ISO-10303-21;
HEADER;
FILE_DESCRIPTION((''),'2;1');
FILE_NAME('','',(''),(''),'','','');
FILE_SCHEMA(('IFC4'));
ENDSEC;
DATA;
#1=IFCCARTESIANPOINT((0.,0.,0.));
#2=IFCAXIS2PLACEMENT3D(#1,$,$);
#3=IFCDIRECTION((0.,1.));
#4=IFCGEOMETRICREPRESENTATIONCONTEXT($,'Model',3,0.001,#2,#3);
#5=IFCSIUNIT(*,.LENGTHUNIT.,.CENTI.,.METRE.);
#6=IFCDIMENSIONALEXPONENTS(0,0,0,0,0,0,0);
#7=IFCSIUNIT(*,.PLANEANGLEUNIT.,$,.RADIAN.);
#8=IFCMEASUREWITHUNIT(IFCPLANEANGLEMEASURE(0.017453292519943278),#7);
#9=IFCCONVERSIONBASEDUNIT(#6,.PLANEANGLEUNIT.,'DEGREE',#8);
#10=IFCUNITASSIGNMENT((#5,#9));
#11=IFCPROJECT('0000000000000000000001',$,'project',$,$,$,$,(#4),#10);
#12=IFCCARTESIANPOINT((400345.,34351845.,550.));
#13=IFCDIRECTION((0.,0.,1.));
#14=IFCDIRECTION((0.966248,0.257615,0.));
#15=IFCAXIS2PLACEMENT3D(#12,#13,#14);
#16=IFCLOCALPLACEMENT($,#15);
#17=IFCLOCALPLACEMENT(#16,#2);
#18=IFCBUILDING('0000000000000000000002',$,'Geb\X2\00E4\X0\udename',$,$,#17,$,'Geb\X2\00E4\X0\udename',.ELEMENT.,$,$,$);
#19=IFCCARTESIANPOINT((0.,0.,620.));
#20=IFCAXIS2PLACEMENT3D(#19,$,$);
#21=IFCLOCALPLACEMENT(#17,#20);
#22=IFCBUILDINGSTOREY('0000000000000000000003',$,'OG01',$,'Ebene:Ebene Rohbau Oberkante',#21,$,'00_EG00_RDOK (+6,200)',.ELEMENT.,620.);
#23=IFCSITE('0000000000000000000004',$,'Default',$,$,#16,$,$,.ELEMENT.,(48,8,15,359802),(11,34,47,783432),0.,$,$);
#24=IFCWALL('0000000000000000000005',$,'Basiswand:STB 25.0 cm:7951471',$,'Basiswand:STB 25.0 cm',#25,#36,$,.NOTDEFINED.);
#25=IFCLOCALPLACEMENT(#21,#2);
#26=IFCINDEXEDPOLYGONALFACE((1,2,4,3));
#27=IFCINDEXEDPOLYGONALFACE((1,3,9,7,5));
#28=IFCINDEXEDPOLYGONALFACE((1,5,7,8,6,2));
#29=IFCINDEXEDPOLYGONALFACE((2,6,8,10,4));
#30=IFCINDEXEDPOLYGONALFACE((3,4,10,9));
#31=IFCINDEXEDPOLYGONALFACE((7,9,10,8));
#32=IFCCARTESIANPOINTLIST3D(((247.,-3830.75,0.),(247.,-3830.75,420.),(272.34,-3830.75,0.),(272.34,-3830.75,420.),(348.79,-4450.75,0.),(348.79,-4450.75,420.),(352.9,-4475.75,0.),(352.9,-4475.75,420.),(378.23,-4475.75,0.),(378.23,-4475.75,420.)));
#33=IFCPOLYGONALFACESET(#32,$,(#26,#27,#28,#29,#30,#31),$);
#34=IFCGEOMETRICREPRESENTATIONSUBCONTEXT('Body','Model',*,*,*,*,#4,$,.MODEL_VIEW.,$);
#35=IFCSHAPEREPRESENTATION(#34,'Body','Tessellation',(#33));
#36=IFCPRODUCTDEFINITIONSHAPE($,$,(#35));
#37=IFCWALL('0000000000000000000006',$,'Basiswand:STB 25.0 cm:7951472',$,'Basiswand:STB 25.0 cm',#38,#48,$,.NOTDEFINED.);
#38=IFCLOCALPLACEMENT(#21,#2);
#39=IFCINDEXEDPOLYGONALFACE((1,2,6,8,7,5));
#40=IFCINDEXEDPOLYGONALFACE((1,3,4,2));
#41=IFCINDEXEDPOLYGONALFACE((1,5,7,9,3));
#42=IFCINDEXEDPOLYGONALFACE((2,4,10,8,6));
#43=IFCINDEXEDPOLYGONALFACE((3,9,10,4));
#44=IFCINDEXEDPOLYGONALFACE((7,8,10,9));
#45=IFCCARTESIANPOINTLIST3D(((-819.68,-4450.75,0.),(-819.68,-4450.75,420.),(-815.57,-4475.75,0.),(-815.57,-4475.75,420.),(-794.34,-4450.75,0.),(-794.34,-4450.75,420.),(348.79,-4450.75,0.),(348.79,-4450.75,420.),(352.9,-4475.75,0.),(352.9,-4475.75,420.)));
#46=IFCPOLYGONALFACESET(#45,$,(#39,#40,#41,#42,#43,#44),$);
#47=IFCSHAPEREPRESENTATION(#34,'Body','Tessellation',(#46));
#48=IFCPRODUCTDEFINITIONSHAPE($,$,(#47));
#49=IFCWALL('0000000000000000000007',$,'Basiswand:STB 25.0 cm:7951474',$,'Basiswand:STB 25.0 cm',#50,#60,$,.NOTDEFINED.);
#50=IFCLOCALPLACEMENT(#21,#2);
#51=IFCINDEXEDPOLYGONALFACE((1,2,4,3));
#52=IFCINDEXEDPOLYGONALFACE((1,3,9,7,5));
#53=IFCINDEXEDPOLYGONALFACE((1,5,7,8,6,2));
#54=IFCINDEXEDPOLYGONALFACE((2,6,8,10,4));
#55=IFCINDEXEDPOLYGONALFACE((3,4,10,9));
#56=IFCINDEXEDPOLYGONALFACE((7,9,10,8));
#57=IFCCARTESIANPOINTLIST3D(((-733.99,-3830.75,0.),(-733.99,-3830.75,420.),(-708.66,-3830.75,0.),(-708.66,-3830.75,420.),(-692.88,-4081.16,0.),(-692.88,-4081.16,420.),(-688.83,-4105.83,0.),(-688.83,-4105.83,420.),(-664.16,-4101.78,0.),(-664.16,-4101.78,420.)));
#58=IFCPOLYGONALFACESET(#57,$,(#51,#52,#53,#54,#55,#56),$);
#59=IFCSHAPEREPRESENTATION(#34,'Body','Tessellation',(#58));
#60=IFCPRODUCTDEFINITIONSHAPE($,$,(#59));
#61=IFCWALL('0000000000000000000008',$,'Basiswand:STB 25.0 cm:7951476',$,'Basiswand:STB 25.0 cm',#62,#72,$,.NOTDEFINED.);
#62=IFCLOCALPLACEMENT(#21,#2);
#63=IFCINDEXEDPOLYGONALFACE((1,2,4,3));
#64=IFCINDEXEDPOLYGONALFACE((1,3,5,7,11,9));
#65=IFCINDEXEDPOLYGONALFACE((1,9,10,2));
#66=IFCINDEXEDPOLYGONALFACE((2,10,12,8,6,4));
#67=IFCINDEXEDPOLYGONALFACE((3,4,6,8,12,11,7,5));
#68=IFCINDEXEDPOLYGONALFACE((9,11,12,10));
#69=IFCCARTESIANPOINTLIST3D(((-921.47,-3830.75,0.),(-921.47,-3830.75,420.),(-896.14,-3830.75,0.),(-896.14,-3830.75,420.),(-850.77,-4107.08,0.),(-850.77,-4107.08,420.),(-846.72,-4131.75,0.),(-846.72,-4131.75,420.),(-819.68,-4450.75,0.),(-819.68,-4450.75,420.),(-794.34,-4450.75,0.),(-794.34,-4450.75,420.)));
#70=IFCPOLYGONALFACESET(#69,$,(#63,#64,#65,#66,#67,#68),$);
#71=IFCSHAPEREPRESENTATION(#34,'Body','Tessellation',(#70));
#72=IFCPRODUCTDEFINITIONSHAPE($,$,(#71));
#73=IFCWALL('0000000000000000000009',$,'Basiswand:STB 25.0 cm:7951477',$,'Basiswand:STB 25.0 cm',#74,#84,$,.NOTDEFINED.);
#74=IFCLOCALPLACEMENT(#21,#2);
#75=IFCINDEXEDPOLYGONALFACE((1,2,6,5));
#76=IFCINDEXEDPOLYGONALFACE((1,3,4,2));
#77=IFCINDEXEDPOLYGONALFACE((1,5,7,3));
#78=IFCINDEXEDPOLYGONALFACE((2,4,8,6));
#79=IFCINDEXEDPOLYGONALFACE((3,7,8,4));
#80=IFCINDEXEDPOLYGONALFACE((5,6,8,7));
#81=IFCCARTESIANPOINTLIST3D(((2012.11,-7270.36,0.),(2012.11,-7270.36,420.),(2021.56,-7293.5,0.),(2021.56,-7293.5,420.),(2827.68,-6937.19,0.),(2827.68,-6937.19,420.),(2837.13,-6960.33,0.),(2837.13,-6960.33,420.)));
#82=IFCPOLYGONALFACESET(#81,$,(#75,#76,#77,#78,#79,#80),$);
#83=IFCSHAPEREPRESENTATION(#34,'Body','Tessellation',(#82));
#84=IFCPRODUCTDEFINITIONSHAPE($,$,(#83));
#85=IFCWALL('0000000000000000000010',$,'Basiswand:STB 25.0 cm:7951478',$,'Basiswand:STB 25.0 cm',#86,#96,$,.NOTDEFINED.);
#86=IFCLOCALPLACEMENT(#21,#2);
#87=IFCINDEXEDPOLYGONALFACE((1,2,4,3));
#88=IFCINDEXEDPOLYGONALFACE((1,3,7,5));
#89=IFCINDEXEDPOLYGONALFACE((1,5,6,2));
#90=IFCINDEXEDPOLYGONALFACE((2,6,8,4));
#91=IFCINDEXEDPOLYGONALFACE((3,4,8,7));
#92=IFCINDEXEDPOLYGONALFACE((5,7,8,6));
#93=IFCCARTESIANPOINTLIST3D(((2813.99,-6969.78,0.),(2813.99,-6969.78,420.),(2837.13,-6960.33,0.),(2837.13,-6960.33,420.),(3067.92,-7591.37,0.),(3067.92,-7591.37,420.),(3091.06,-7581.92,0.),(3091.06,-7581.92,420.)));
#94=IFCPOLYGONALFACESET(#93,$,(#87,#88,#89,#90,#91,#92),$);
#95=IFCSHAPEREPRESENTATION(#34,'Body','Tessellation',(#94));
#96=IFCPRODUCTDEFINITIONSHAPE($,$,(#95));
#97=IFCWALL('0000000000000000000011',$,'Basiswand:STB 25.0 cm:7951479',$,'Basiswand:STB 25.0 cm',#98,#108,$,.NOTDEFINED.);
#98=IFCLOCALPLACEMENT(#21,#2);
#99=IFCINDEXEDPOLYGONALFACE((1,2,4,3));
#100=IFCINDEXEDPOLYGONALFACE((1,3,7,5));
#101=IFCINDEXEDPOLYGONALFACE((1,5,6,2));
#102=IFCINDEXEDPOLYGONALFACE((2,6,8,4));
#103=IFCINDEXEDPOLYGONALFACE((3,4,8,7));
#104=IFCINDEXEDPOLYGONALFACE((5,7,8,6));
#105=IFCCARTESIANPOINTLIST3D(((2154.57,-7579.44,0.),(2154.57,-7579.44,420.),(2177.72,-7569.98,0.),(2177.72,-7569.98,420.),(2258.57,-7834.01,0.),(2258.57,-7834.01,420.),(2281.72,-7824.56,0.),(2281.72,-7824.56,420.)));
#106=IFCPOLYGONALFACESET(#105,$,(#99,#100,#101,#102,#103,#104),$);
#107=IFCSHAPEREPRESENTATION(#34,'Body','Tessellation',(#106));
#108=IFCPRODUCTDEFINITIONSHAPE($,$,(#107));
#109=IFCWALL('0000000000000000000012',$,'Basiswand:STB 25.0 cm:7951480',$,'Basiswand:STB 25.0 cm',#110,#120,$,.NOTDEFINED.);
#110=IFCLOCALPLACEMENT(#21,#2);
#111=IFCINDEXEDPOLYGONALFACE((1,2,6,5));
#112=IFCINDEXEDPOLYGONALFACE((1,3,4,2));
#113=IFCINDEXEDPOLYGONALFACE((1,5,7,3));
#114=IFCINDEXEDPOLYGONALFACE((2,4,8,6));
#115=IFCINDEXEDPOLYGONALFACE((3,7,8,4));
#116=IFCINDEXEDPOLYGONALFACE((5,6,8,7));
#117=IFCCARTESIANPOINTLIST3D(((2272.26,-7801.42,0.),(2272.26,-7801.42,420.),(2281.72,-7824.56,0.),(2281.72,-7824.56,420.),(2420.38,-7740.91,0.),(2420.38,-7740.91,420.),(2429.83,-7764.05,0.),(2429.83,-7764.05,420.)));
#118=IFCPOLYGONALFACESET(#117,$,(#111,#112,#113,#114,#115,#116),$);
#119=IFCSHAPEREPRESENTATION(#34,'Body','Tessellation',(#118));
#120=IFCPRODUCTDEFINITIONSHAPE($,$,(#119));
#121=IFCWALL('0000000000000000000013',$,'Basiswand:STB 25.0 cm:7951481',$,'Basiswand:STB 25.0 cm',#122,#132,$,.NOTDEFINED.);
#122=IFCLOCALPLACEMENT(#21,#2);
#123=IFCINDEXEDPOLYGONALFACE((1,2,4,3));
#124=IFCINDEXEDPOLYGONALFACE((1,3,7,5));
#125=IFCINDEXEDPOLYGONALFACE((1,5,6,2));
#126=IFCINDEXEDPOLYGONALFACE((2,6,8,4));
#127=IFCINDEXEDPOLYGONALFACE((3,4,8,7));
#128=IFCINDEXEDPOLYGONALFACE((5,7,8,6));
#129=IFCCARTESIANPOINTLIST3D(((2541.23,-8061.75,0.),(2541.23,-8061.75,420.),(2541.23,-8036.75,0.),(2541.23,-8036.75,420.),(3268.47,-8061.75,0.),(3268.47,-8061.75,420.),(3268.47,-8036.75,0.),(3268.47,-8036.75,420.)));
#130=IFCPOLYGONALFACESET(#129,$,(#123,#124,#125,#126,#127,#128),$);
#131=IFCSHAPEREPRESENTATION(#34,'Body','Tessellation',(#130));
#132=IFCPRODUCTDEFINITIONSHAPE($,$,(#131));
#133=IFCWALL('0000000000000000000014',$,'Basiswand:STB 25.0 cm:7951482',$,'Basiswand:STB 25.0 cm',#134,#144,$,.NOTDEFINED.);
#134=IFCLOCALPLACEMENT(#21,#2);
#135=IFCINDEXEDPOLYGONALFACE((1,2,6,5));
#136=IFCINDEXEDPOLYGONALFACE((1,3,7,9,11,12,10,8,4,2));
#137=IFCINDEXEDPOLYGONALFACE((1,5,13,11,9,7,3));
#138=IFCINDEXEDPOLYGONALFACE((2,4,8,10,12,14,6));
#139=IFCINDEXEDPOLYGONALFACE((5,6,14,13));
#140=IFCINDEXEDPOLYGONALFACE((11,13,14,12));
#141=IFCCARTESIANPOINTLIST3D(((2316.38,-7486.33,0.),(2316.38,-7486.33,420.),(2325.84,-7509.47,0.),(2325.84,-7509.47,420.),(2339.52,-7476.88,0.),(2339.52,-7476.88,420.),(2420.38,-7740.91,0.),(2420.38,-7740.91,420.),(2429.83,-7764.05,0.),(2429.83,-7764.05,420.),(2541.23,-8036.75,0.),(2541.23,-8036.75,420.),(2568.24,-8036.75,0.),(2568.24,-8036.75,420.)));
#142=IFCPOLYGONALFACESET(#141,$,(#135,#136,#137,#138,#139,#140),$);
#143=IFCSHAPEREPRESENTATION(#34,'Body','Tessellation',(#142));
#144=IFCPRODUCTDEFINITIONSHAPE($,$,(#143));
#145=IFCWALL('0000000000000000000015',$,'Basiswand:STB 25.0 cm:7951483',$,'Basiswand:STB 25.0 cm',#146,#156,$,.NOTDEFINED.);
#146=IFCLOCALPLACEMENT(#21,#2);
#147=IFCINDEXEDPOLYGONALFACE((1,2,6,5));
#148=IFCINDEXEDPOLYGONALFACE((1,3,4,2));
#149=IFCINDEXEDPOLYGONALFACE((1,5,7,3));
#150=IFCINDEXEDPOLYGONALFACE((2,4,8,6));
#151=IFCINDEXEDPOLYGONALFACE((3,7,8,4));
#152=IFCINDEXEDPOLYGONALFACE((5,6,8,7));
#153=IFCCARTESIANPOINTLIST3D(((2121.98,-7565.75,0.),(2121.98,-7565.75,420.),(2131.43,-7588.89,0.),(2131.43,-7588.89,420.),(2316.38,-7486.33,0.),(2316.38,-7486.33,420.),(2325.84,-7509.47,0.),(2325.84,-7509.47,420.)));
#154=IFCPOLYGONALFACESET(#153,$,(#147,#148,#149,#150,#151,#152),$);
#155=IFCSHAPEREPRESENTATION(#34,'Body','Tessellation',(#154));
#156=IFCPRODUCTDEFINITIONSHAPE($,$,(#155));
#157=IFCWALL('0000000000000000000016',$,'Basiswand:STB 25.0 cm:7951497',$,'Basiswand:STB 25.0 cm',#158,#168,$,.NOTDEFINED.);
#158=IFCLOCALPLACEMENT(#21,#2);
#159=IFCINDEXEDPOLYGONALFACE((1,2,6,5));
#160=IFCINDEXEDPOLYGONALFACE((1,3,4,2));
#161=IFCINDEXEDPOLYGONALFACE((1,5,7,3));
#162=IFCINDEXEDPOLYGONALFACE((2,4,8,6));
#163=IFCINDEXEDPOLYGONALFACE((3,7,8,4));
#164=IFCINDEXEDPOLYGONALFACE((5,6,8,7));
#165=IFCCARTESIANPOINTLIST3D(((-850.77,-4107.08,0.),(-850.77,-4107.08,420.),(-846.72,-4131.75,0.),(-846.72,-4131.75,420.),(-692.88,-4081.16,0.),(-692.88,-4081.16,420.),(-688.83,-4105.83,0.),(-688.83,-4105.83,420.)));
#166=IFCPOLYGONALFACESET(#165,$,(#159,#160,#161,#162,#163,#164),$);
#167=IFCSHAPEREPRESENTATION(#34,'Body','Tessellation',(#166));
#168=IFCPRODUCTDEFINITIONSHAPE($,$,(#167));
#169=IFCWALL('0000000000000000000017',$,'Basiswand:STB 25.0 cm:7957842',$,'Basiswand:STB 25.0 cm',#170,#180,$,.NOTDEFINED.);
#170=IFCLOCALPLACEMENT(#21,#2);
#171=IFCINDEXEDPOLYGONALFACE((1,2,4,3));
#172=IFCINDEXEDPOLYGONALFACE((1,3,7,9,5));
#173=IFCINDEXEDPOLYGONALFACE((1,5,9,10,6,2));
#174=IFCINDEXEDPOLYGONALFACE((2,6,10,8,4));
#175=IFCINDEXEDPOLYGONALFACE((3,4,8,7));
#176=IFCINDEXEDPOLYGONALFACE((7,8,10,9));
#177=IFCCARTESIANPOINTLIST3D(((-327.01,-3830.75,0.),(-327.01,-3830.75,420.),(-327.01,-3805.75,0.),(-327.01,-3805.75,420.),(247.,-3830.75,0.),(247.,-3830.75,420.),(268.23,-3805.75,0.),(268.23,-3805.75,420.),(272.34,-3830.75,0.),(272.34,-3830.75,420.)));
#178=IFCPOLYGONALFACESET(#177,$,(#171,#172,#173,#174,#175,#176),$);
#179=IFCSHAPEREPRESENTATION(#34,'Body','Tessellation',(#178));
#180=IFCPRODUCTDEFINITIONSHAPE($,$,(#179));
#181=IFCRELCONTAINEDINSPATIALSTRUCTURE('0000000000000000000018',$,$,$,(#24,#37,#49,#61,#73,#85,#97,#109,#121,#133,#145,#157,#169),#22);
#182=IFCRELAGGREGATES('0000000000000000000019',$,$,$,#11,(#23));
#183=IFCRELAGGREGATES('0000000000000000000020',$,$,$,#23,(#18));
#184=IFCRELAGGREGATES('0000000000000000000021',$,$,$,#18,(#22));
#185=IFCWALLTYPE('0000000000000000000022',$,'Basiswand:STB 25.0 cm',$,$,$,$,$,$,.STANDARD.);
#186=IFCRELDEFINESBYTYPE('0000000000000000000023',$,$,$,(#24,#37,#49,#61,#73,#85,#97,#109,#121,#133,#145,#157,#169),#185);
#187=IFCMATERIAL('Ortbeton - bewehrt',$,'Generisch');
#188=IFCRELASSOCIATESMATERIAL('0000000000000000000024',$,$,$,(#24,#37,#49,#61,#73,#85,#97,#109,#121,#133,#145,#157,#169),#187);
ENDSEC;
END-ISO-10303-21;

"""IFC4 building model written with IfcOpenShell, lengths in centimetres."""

from ifc_helpers import new_model, entity, si_unit, converted_unit, direction, frame, origin, place, context, subcontext, project, spatial, indexed_curve, outline, extrude, material, type_object, element, save


model = new_model("IFC4")

# Units and contexts
model_context = context("Model", 3, precision=0.001, world=origin(), true_north=direction((0.0, 1.0)))
body_context = subcontext(model_context, "Body", "Model", "MODEL_VIEW")
ifc_project = project(units=[si_unit("LENGTHUNIT", "METRE", prefix="CENTI"), converted_unit("PLANEANGLEUNIT", "DEGREE", entity("IfcPlaneAngleMeasure", 0.017453292519943278), si_unit("PLANEANGLEUNIT", "RADIAN"), dimensions=[0, 0, 0, 0, 0, 0, 0])], contexts=[model_context])

# Site, building, storey
site_placement = place(None, frame((400345.0, 34351845.0, 550.0), z_axis=(0.0, 0.0, 1.0), x_axis=(0.966248, 0.257615, 0.0)))
site = spatial("IfcSite", under=ifc_project, at=site_placement, Name="Default", CompositionType="ELEMENT", RefLatitude=(48, 8, 15, 359802), RefLongitude=(11, 34, 47, 783432), RefElevation=0.0)
building_placement = place(site_placement, origin())
building = spatial("IfcBuilding", under=site, at=building_placement, Name="Gebäudename", LongName="Gebäudename", CompositionType="ELEMENT")
storey_placement = place(building_placement, frame((0.0, 0.0, 620.0)))
storey = spatial("IfcBuildingStorey", under=building, at=storey_placement, Name="OG01", ObjectType="Ebene:Ebene Rohbau Oberkante", LongName="00_EG00_RDOK (+6,200)", CompositionType="ELEMENT", Elevation=620.0)

# Shared definitions
ifc_material = material(Name="Ortbeton - bewehrt", Category="Generisch")

# Walls
wall_type = type_object("IfcWallType", Name="Basiswand:STB 25.0 cm", PredefinedType="STANDARD")
wall_1_placement = place(storey_placement, frame((259.34, -3828.72, 0.0), z_axis=(0.0, 0.0, 1.0), x_axis=(0.162011, -0.986789, 0.0)))
element("IfcWall", 1, at=wall_1_placement, inside=storey, type_object=wall_type, material=ifc_material, Name="Basiswand:STB 25.0 cm:7951471", ObjectType="Basiswand:STB 25.0 cm", PredefinedType="NOTDEFINED", context=body_context, shape_type="SweptSolid", body=[
    extrude(outline(indexed_curve([(653.64, -12.5), (657.74, 12.5), (4.1, 12.5), (0.0, -12.5), (628.3, -12.5), (653.64, -12.5)], self_intersect=False)), origin(), (0.0, 0.0, 1.0), 420.0),
])
wall_2_placement = place(storey_placement, frame((352.9, -4463.25, 0.0), z_axis=(0.0, 0.0, 1.0), x_axis=(-1.0, 0.0, 0.0)))
element("IfcWall", 2, at=wall_2_placement, inside=storey, type_object=wall_type, material=ifc_material, Name="Basiswand:STB 25.0 cm:7951472", ObjectType="Basiswand:STB 25.0 cm", PredefinedType="NOTDEFINED", context=body_context, shape_type="SweptSolid", body=[
    extrude(outline(indexed_curve([(1172.58, -12.5), (1168.47, 12.5), (0.0, 12.5), (4.1, -12.5), (1147.24, -12.5), (1172.58, -12.5)], self_intersect=False)), origin(), (0.0, 0.0, 1.0), 420.0),
])
wall_3_placement = place(storey_placement, frame((-721.66, -3828.72, 0.0), z_axis=(0.0, 0.0, 1.0), x_axis=(0.162011, -0.986789, 0.0)))
element("IfcWall", 3, at=wall_3_placement, inside=storey, type_object=wall_type, material=ifc_material, Name="Basiswand:STB 25.0 cm:7951474", ObjectType="Basiswand:STB 25.0 cm", PredefinedType="NOTDEFINED", context=body_context, shape_type="SweptSolid", body=[
    extrude(outline(indexed_curve([(278.77, -12.5), (278.77, 12.5), (4.1, 12.5), (0.0, -12.5), (253.77, -12.5), (278.77, -12.5)], self_intersect=False)), origin(), (0.0, 0.0, 1.0), 420.0),
])
wall_4_placement = place(storey_placement, frame((-806.68, -4452.77, 0.0), z_axis=(0.0, 0.0, 1.0), x_axis=(-0.162011, 0.986789, 0.0)))
element("IfcWall", 4, at=wall_4_placement, inside=storey, type_object=wall_type, material=ifc_material, Name="Basiswand:STB 25.0 cm:7951476", ObjectType="Basiswand:STB 25.0 cm", PredefinedType="NOTDEFINED", context=body_context, shape_type="SweptSolid", body=[
    extrude(outline(indexed_curve([(628.3, -12.5), (632.41, 12.5), (4.1, 12.5), (0.0, -12.5), (323.26, -12.5), (348.26, -12.5), (628.3, -12.5)], self_intersect=False)), origin(), (0.0, 0.0, 1.0), 420.0),
])
wall_5_placement = place(storey_placement, frame((2016.84, -7281.93, 0.0), z_axis=(0.0, 0.0, 1.0), x_axis=(0.925734, 0.378175, 0.0)))
element("IfcWall", 5, at=wall_5_placement, inside=storey, type_object=wall_type, material=ifc_material, Name="Basiswand:STB 25.0 cm:7951477", ObjectType="Basiswand:STB 25.0 cm", PredefinedType="NOTDEFINED", context=body_context, shape_type="SweptSolid", body=[
    extrude(outline(indexed_curve([(881.0, 12.5), (0.0, 12.5), (0.0, -12.5), (881.0, -12.5), (881.0, 12.5)], self_intersect=False)), origin(), (0.0, 0.0, 1.0), 420.0),
])
wall_6_placement = place(storey_placement, frame((2825.56, -6965.06, 0.0), z_axis=(0.0, 0.0, 1.0), x_axis=(0.378175, -0.925734, 0.0)))
element("IfcWall", 6, at=wall_6_placement, inside=storey, type_object=wall_type, material=ifc_material, Name="Basiswand:STB 25.0 cm:7951478", ObjectType="Basiswand:STB 25.0 cm", PredefinedType="NOTDEFINED", context=body_context, shape_type="SweptSolid", body=[
    extrude(outline(indexed_curve([(671.46, 12.5), (0.0, 12.5), (0.0, -12.5), (671.46, -12.5), (671.46, 12.5)], self_intersect=False)), origin(), (0.0, 0.0, 1.0), 420.0),
])
wall_7_placement = place(storey_placement, frame((2166.15, -7574.71, 0.0), z_axis=(0.0, 0.0, 1.0), x_axis=(0.378175, -0.925734, 0.0)))
element("IfcWall", 7, at=wall_7_placement, inside=storey, type_object=wall_type, material=ifc_material, Name="Basiswand:STB 25.0 cm:7951479", ObjectType="Basiswand:STB 25.0 cm", PredefinedType="NOTDEFINED", context=body_context, shape_type="SweptSolid", body=[
    extrude(outline(indexed_curve([(275.0, 12.5), (0.0, 12.5), (0.0, -12.5), (275.0, -12.5), (275.0, 12.5)], self_intersect=False)), origin(), (0.0, 0.0, 1.0), 420.0),
])
wall_8_placement = place(storey_placement, frame((2276.99, -7812.99, 0.0), z_axis=(0.0, 0.0, 1.0), x_axis=(0.925734, 0.378175, 0.0)))
element("IfcWall", 8, at=wall_8_placement, inside=storey, type_object=wall_type, material=ifc_material, Name="Basiswand:STB 25.0 cm:7951480", ObjectType="Basiswand:STB 25.0 cm", PredefinedType="NOTDEFINED", context=body_context, shape_type="SweptSolid", body=[
    extrude(outline(indexed_curve([(160.0, 12.5), (0.0, 12.5), (0.0, -12.5), (160.0, -12.5), (160.0, 12.5)], self_intersect=False)), origin(), (0.0, 0.0, 1.0), 420.0),
])
wall_9_placement = place(storey_placement, frame((3268.47, -8049.25, 0.0), z_axis=(0.0, 0.0, 1.0), x_axis=(-1.0, 0.0, 0.0)))
element("IfcWall", 9, at=wall_9_placement, inside=storey, type_object=wall_type, material=ifc_material, Name="Basiswand:STB 25.0 cm:7951481", ObjectType="Basiswand:STB 25.0 cm", PredefinedType="NOTDEFINED", context=body_context, shape_type="SweptSolid", body=[
    extrude(outline(indexed_curve([(727.24, 12.5), (0.0, 12.5), (0.0, -12.5), (727.24, -12.5), (727.24, 12.5)], self_intersect=False)), origin(), (0.0, 0.0, 1.0), 420.0),
])
wall_10_placement = place(storey_placement, frame((2327.95, -7481.6, 0.0), z_axis=(0.0, 0.0, 1.0), x_axis=(0.378175, -0.925734, 0.0)))
element("IfcWall", 10, at=wall_10_placement, inside=storey, type_object=wall_type, material=ifc_material, Name="Basiswand:STB 25.0 cm:7951482", ObjectType="Basiswand:STB 25.0 cm", PredefinedType="NOTDEFINED", context=body_context, shape_type="SweptSolid", body=[
    extrude(outline(indexed_curve([(594.57, -12.5), (604.78, 12.5), (0.0, 12.5), (0.0, -12.5), (25.0, -12.5), (275.0, -12.5), (300.0, -12.5), (594.57, -12.5)], self_intersect=False)), origin(), (0.0, 0.0, 1.0), 420.0),
])
wall_11_placement = place(storey_placement, frame((2126.7, -7577.32, 0.0), z_axis=(0.0, 0.0, 1.0), x_axis=(0.925734, 0.378175, 0.0)))
element("IfcWall", 11, at=wall_11_placement, inside=storey, type_object=wall_type, material=ifc_material, Name="Basiswand:STB 25.0 cm:7951483", ObjectType="Basiswand:STB 25.0 cm", PredefinedType="NOTDEFINED", context=body_context, shape_type="SweptSolid", body=[
    extrude(outline(indexed_curve([(210.0, 12.5), (0.0, 12.5), (0.0, -12.5), (210.0, -12.5), (210.0, 12.5)], self_intersect=False)), origin(), (0.0, 0.0, 1.0), 420.0),
])
wall_12_placement = place(storey_placement, frame((-848.74, -4119.42, 0.0), z_axis=(0.0, 0.0, 1.0), x_axis=(0.986789, 0.162011, 0.0)))
element("IfcWall", 12, at=wall_12_placement, inside=storey, type_object=wall_type, material=ifc_material, Name="Basiswand:STB 25.0 cm:7951497", ObjectType="Basiswand:STB 25.0 cm", PredefinedType="NOTDEFINED", context=body_context, shape_type="SweptSolid", body=[
    extrude(outline(indexed_curve([(160.0, 12.5), (0.0, 12.5), (0.0, -12.5), (160.0, -12.5), (160.0, 12.5)], self_intersect=False)), origin(), (0.0, 0.0, 1.0), 420.0),
])
wall_13_placement = place(storey_placement, frame((-327.01, -3818.25, 0.0)))
element("IfcWall", 13, at=wall_13_placement, inside=storey, type_object=wall_type, material=ifc_material, Name="Basiswand:STB 25.0 cm:7957842", ObjectType="Basiswand:STB 25.0 cm", PredefinedType="NOTDEFINED", context=body_context, shape_type="SweptSolid", body=[
    extrude(outline(indexed_curve([(599.35, -12.5), (595.25, 12.5), (0.0, 12.5), (0.0, -12.5), (574.02, -12.5), (599.35, -12.5)], self_intersect=False)), origin(), (0.0, 0.0, 1.0), 420.0),
])

save(model, "model.ifc")
